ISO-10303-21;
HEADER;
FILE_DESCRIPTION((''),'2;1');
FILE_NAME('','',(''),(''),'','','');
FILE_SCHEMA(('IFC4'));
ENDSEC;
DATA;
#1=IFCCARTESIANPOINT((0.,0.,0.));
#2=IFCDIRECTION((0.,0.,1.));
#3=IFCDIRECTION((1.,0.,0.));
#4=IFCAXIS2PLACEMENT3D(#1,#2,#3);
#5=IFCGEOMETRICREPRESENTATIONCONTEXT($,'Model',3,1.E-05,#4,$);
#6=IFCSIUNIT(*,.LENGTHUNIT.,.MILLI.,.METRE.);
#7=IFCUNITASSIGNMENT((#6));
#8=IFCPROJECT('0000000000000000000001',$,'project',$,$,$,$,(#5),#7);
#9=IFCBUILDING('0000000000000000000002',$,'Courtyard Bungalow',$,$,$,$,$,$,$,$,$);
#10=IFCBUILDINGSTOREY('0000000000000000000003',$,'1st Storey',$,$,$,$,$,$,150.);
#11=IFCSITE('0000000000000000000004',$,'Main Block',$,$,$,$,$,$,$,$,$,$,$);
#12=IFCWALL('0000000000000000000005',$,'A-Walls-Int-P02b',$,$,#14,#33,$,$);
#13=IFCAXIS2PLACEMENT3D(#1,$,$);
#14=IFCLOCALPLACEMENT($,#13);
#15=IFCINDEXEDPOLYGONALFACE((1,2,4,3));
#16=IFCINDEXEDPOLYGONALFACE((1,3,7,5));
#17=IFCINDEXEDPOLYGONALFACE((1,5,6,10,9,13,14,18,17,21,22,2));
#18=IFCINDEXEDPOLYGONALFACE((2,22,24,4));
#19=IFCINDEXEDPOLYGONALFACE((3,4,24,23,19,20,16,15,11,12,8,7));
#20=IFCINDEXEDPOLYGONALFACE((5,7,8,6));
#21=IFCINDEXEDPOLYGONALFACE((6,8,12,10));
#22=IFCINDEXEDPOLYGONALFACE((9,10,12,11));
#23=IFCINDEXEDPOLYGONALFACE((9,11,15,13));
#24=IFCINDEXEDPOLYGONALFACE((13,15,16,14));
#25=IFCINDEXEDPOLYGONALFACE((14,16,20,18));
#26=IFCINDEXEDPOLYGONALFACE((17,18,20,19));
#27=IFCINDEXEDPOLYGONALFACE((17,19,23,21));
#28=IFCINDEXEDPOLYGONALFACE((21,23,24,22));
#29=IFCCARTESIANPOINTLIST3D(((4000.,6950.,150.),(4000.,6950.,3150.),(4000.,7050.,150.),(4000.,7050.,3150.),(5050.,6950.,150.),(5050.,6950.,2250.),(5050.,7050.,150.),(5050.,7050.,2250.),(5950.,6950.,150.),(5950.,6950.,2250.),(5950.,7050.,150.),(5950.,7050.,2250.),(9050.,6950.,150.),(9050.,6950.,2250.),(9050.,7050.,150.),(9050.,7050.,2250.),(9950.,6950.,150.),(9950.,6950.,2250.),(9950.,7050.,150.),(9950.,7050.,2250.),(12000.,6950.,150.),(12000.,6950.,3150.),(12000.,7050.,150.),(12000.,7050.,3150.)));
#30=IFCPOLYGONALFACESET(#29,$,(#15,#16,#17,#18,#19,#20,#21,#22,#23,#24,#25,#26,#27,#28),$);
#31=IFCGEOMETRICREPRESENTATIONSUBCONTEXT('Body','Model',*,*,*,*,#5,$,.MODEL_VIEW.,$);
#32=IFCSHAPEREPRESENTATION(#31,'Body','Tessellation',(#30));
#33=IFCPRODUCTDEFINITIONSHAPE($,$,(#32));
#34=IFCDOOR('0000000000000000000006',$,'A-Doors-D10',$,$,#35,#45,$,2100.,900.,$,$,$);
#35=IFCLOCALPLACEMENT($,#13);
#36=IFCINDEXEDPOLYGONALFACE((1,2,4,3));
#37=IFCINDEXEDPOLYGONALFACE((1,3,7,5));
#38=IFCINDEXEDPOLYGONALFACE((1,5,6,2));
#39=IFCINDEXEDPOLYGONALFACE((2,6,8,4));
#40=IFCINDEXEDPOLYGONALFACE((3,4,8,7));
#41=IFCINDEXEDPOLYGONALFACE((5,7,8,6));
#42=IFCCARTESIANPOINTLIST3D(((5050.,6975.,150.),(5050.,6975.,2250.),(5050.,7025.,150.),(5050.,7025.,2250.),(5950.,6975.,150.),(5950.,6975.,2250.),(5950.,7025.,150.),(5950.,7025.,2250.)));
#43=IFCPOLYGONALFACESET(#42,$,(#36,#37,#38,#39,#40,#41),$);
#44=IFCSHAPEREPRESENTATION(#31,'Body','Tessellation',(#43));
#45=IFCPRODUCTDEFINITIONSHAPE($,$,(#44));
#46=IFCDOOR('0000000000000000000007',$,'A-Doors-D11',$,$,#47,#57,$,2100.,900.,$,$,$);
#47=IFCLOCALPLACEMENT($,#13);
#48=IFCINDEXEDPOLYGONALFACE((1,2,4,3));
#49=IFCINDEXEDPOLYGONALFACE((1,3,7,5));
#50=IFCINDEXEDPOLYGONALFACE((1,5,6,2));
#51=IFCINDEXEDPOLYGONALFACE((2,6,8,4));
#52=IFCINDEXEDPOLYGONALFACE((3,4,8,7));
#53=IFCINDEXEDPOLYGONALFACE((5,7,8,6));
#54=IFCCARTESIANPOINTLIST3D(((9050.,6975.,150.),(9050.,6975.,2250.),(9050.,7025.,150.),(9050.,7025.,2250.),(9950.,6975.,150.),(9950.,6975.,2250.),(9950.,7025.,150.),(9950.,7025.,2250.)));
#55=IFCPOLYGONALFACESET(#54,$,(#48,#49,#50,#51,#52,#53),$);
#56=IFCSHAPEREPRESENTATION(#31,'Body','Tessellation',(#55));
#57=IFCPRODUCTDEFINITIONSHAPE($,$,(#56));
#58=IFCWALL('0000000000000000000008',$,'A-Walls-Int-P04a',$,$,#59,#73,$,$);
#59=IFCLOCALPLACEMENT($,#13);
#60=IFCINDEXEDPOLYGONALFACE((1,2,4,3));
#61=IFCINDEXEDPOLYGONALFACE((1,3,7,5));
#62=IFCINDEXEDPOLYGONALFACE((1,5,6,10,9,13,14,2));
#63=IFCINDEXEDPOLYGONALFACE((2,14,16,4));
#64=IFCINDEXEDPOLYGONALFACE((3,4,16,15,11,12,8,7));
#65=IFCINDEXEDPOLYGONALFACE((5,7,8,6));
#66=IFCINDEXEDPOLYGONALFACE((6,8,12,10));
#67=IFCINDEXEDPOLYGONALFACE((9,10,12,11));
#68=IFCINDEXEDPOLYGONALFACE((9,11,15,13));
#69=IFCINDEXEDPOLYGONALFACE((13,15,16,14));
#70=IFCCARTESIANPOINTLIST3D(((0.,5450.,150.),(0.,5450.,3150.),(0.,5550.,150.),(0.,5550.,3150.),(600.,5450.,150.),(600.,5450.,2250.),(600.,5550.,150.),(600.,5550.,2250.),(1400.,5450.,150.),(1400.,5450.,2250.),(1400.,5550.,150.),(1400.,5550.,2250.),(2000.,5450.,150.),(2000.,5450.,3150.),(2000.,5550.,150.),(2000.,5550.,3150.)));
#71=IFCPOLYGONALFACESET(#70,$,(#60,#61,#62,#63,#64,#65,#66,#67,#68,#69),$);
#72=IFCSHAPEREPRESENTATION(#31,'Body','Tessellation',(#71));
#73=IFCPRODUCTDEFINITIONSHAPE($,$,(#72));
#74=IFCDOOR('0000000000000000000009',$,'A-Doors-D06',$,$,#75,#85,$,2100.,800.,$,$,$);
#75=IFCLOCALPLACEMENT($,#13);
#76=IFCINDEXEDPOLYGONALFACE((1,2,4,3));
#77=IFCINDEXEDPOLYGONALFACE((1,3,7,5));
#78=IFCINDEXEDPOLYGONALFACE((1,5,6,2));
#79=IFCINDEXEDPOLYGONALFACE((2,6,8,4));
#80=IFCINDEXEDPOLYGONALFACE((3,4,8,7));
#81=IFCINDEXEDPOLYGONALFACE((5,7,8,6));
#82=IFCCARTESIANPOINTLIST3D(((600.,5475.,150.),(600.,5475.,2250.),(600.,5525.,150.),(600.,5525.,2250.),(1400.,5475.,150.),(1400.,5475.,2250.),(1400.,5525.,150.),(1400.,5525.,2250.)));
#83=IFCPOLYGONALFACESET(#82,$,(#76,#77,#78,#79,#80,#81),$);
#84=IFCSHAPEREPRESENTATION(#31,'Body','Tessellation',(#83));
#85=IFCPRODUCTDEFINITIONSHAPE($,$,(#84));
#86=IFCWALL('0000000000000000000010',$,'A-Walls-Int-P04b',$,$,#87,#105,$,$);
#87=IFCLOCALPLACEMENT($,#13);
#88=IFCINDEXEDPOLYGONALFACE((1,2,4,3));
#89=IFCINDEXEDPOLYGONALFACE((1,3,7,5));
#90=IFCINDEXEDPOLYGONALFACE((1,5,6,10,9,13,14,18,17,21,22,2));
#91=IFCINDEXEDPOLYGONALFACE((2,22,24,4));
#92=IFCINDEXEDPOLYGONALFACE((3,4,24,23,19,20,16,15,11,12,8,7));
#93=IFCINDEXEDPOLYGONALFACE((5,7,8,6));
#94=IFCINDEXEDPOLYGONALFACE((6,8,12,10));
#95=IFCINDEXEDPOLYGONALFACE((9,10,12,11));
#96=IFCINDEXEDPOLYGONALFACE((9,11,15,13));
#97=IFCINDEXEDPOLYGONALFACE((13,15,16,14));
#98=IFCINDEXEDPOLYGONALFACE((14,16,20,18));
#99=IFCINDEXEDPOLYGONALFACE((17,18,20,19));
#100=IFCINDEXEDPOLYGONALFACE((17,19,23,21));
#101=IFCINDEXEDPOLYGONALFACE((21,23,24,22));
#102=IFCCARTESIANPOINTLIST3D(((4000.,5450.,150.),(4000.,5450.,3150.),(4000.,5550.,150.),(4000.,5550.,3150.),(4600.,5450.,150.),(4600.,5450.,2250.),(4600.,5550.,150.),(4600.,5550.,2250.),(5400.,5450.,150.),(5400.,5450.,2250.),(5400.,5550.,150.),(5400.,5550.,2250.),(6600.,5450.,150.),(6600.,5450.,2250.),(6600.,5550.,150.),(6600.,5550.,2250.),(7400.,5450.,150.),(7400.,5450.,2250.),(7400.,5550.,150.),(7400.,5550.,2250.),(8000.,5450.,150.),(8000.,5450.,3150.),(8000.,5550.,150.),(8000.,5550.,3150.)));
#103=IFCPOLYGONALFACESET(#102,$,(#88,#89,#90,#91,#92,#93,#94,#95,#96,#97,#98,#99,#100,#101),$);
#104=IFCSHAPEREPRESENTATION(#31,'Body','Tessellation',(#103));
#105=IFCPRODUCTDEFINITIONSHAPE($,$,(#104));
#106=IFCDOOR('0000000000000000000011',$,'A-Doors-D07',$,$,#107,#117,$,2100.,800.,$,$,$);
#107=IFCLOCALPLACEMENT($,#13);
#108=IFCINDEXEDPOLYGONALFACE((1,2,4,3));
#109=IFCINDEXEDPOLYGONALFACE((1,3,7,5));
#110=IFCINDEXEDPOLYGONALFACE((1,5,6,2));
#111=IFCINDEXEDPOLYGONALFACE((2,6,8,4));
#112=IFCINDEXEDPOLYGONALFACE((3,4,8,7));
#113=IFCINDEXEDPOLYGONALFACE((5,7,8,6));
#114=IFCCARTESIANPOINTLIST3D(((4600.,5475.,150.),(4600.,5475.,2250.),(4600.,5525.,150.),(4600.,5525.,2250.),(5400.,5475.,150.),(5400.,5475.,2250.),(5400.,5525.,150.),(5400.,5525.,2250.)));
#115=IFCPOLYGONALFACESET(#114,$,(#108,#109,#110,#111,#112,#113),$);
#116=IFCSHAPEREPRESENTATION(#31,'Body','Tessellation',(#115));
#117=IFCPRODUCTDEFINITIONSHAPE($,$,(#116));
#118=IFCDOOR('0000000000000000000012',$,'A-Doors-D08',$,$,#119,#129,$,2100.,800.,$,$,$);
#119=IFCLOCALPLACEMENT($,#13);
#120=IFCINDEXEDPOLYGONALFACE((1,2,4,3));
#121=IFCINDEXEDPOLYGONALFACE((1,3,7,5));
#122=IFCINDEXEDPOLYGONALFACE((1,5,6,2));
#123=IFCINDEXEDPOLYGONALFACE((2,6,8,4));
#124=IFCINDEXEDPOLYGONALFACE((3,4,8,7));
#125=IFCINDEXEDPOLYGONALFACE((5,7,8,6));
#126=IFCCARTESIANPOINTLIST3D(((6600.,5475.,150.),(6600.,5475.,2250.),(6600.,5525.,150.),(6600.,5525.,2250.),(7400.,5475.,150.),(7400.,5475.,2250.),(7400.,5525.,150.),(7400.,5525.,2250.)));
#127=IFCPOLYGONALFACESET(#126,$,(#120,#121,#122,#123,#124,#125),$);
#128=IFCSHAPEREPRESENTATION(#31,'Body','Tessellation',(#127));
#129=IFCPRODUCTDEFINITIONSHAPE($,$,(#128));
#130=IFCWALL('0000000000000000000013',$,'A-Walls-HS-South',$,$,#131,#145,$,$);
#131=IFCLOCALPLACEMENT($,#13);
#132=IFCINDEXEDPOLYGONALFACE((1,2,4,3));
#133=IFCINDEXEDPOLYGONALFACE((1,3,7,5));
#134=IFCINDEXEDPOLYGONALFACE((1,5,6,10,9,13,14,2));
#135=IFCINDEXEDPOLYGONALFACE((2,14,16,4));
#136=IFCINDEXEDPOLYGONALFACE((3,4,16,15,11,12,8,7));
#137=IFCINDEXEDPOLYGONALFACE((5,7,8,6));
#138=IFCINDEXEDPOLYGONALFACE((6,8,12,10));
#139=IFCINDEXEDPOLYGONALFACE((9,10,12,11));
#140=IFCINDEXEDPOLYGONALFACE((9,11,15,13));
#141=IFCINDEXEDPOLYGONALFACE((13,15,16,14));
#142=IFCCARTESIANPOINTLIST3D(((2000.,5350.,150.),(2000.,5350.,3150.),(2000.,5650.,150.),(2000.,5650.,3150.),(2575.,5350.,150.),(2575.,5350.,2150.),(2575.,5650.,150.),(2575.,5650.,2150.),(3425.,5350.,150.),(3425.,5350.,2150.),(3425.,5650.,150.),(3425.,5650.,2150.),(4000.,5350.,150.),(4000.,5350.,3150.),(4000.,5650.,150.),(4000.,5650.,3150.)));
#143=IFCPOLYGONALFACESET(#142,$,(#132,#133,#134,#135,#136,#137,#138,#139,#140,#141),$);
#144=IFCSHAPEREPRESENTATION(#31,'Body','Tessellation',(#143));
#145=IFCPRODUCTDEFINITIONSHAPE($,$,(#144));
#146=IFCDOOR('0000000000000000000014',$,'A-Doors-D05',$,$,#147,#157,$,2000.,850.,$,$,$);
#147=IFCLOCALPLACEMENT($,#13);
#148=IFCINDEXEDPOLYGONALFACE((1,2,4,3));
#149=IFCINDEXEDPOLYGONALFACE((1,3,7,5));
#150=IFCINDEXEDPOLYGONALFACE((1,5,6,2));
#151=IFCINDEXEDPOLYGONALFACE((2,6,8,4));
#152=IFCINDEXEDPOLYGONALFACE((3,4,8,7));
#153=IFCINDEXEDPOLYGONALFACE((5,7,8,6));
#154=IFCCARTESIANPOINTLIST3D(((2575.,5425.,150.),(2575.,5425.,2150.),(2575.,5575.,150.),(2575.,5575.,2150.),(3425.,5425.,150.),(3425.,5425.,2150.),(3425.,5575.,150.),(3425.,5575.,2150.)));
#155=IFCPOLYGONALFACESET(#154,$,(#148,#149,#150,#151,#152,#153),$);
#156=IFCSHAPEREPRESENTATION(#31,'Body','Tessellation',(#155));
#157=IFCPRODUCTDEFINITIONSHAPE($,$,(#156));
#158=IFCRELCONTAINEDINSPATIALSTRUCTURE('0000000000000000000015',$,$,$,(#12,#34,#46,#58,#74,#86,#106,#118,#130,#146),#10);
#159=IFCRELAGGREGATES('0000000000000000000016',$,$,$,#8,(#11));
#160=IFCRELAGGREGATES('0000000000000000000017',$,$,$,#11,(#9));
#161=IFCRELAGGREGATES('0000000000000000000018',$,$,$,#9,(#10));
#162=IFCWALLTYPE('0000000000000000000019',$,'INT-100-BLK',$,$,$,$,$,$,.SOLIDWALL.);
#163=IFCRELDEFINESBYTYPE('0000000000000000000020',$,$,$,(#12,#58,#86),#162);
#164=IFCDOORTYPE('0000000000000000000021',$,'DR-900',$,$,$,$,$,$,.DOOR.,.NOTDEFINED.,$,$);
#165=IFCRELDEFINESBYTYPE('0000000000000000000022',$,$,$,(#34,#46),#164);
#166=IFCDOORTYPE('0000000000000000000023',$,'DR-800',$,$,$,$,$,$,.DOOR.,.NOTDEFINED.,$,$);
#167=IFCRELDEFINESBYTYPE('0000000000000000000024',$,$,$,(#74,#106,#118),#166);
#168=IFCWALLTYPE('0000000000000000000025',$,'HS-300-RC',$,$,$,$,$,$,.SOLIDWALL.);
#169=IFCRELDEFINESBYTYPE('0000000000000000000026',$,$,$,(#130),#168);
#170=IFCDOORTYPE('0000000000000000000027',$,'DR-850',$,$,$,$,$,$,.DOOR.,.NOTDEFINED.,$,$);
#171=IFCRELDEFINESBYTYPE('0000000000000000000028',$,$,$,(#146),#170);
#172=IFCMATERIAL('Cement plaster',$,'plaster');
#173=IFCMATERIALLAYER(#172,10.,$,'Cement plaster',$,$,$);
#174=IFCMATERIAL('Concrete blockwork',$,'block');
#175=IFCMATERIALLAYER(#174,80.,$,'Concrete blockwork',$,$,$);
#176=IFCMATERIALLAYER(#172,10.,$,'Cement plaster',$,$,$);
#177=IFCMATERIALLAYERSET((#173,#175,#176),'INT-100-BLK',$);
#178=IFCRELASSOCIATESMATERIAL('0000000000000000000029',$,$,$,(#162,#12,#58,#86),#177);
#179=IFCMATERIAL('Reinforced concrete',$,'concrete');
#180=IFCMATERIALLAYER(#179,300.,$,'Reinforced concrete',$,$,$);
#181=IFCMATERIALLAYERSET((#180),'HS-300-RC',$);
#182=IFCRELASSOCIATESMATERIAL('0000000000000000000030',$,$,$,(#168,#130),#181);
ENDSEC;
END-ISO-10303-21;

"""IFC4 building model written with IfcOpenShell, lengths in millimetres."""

from ifc_helpers import new_model, si_unit, frame, origin_with_axes, place, context, subcontext, project, spatial, indexed_curve, outline, extrude, material, layer, layer_set, layer_usage, type_object, element, fill, save


model = new_model("IFC4")

# Units and contexts
model_context = context("Model", 3, precision=1e-05, world=origin_with_axes())
body_context = subcontext(model_context, "Body", "Model", "MODEL_VIEW")
ifc_project = project(units=[si_unit("LENGTHUNIT", "METRE", prefix="MILLI")], contexts=[model_context])

# Site, building, storey
site = spatial("IfcSite", under=ifc_project, Name="Main Block")
building = spatial("IfcBuilding", under=site, Name="Courtyard Bungalow")
storey = spatial("IfcBuildingStorey", under=building, Name="1st Storey", Elevation=150.0)

# Shared definitions
ifc_material_1 = material(Name="Reinforced concrete", Category="concrete")

# Shared definitions
ifc_material_2 = material(Name="Cement plaster", Category="plaster")

# Shared definitions
ifc_layer_1 = layer(ifc_material_2, 10.0, Name="Cement plaster")
ifc_material_3 = material(Name="Concrete blockwork", Category="block")
ifc_layer_2 = layer(ifc_material_3, 80.0, Name="Concrete blockwork")
ifc_layer_3 = layer(ifc_material_2, 10.0, Name="Cement plaster")
ifc_layer_set_1 = layer_set([ifc_layer_1, ifc_layer_2, ifc_layer_3], Name="INT-100-BLK")
wall_type_1 = type_object("IfcWallType", Name="INT-100-BLK", PredefinedType="SOLIDWALL", material=ifc_layer_set_1)
door_type_1 = type_object("IfcDoorType", Name="DR-900", OperationType="NOTDEFINED", PredefinedType="DOOR")

# Wall, openings, doors
ifc_layer_usage_1 = layer_usage(ifc_layer_set_1, "AXIS2", "POSITIVE", 0.0)
wall_1_placement = place(None, frame((4000.0, 6950.0, 150.0), z_axis=(0.0, 0.0, 1.0), x_axis=(1.0, 0.0, 0.0)))
wall_1 = element("IfcWall", 1, at=wall_1_placement, inside=storey, type_object=wall_type_1, material=ifc_layer_usage_1, Name="A-Walls-Int-P02b", context=body_context, shape_type="SweptSolid", body=[
    extrude(outline(indexed_curve([(0.0, 0.0), (0.0, 100.0), (8000.0, 100.0), (8000.0, 0.0), (0.0, 0.0)], self_intersect=False)), origin_with_axes(), (0.0, 0.0, 1.0), 3000.0),
])
opening_1_placement = place(wall_1_placement, frame((1500.0, 50.0, 0.0), z_axis=(0.0, 0.0, 1.0), x_axis=(1.0, 0.0, 0.0)))
opening_1 = element("IfcOpeningElement", 2, at=opening_1_placement, cuts=wall_1, PredefinedType="OPENING", context=body_context, shape_type="SweptSolid", body=[
    extrude(outline(indexed_curve([(-450.0, -100.0), (450.0, -100.0), (450.0, 100.0), (-450.0, 100.0)])), None, (0.0, 0.0, 1.0), 2100.0),
])
opening_2_placement = place(wall_1_placement, frame((5500.0, 50.0, 0.0), z_axis=(0.0, 0.0, 1.0), x_axis=(1.0, 0.0, 0.0)))
opening_2 = element("IfcOpeningElement", 3, at=opening_2_placement, cuts=wall_1, PredefinedType="OPENING", context=body_context, shape_type="SweptSolid", body=[
    extrude(outline(indexed_curve([(-450.0, -100.0), (450.0, -100.0), (450.0, 100.0), (-450.0, 100.0)])), None, (0.0, 0.0, 1.0), 2100.0),
])
door_1_placement = place(None, frame((5500.0, 7000.0, 150.0), z_axis=(0.0, 0.0, 1.0), x_axis=(1.0, 0.0, 0.0)))
door_1 = element("IfcDoor", 4, at=door_1_placement, inside=storey, type_object=door_type_1, Name="A-Doors-D10", OverallHeight=2100.0, OverallWidth=900.0, context=body_context, shape_type="SweptSolid", body=[
    extrude(outline(indexed_curve([(-450.0, -25.0), (450.0, -25.0), (450.0, 25.0), (-450.0, 25.0)])), None, (0.0, 0.0, 1.0), 2100.0),
])
fill(opening_1, door_1)
door_2_placement = place(None, frame((9500.0, 7000.0, 150.0), z_axis=(0.0, 0.0, 1.0), x_axis=(1.0, 0.0, 0.0)))
door_2 = element("IfcDoor", 5, at=door_2_placement, inside=storey, type_object=door_type_1, Name="A-Doors-D11", OverallHeight=2100.0, OverallWidth=900.0, context=body_context, shape_type="SweptSolid", body=[
    extrude(outline(indexed_curve([(-450.0, -25.0), (450.0, -25.0), (450.0, 25.0), (-450.0, 25.0)])), None, (0.0, 0.0, 1.0), 2100.0),
])
fill(opening_2, door_2)

# Wall, opening, door
ifc_layer_usage_2 = layer_usage(ifc_layer_set_1, "AXIS2", "POSITIVE", 0.0)
wall_2_placement = place(None, frame((0.0, 5450.0, 150.0), z_axis=(0.0, 0.0, 1.0), x_axis=(1.0, 0.0, 0.0)))
wall_2 = element("IfcWall", 6, at=wall_2_placement, inside=storey, type_object=wall_type_1, material=ifc_layer_usage_2, Name="A-Walls-Int-P04a", context=body_context, shape_type="SweptSolid", body=[
    extrude(outline(indexed_curve([(0.0, 0.0), (0.0, 100.0), (2000.0, 100.0), (2000.0, 0.0), (0.0, 0.0)], self_intersect=False)), origin_with_axes(), (0.0, 0.0, 1.0), 3000.0),
])
opening_3_placement = place(wall_2_placement, frame((1000.0, 50.0, 0.0), z_axis=(0.0, 0.0, 1.0), x_axis=(1.0, 0.0, 0.0)))
opening_3 = element("IfcOpeningElement", 7, at=opening_3_placement, cuts=wall_2, PredefinedType="OPENING", context=body_context, shape_type="SweptSolid", body=[
    extrude(outline(indexed_curve([(-400.0, -100.0), (400.0, -100.0), (400.0, 100.0), (-400.0, 100.0)])), None, (0.0, 0.0, 1.0), 2100.0),
])
door_type_2 = type_object("IfcDoorType", Name="DR-800", OperationType="NOTDEFINED", PredefinedType="DOOR")
door_3_placement = place(None, frame((1000.0, 5500.0, 150.0), z_axis=(0.0, 0.0, 1.0), x_axis=(1.0, 0.0, 0.0)))
door_3 = element("IfcDoor", 8, at=door_3_placement, inside=storey, type_object=door_type_2, Name="A-Doors-D06", OverallHeight=2100.0, OverallWidth=800.0, context=body_context, shape_type="SweptSolid", body=[
    extrude(outline(indexed_curve([(-400.0, -25.0), (400.0, -25.0), (400.0, 25.0), (-400.0, 25.0)])), None, (0.0, 0.0, 1.0), 2100.0),
])
fill(opening_3, door_3)

# Wall, openings, doors
ifc_layer_usage_3 = layer_usage(ifc_layer_set_1, "AXIS2", "POSITIVE", 0.0)
wall_3_placement = place(None, frame((4000.0, 5450.0, 150.0), z_axis=(0.0, 0.0, 1.0), x_axis=(1.0, 0.0, 0.0)))
wall_3 = element("IfcWall", 9, at=wall_3_placement, inside=storey, type_object=wall_type_1, material=ifc_layer_usage_3, Name="A-Walls-Int-P04b", context=body_context, shape_type="SweptSolid", body=[
    extrude(outline(indexed_curve([(0.0, 0.0), (0.0, 100.0), (4000.0, 100.0), (4000.0, 0.0), (0.0, 0.0)], self_intersect=False)), origin_with_axes(), (0.0, 0.0, 1.0), 3000.0),
])
opening_4_placement = place(wall_3_placement, frame((1000.0, 50.0, 0.0), z_axis=(0.0, 0.0, 1.0), x_axis=(1.0, 0.0, 0.0)))
opening_4 = element("IfcOpeningElement", 10, at=opening_4_placement, cuts=wall_3, PredefinedType="OPENING", context=body_context, shape_type="SweptSolid", body=[
    extrude(outline(indexed_curve([(-400.0, -100.0), (400.0, -100.0), (400.0, 100.0), (-400.0, 100.0)])), None, (0.0, 0.0, 1.0), 2100.0),
])
opening_5_placement = place(wall_3_placement, frame((3000.0, 50.0, 0.0), z_axis=(0.0, 0.0, 1.0), x_axis=(1.0, 0.0, 0.0)))
opening_5 = element("IfcOpeningElement", 11, at=opening_5_placement, cuts=wall_3, PredefinedType="OPENING", context=body_context, shape_type="SweptSolid", body=[
    extrude(outline(indexed_curve([(-400.0, -100.0), (400.0, -100.0), (400.0, 100.0), (-400.0, 100.0)])), None, (0.0, 0.0, 1.0), 2100.0),
])
door_4_placement = place(None, frame((5000.0, 5500.0, 150.0), z_axis=(0.0, 0.0, 1.0), x_axis=(1.0, 0.0, 0.0)))
door_4 = element("IfcDoor", 12, at=door_4_placement, inside=storey, type_object=door_type_2, Name="A-Doors-D07", OverallHeight=2100.0, OverallWidth=800.0, context=body_context, shape_type="SweptSolid", body=[
    extrude(outline(indexed_curve([(-400.0, -25.0), (400.0, -25.0), (400.0, 25.0), (-400.0, 25.0)])), None, (0.0, 0.0, 1.0), 2100.0),
])
fill(opening_4, door_4)
door_5_placement = place(None, frame((7000.0, 5500.0, 150.0), z_axis=(0.0, 0.0, 1.0), x_axis=(1.0, 0.0, 0.0)))
door_5 = element("IfcDoor", 13, at=door_5_placement, inside=storey, type_object=door_type_2, Name="A-Doors-D08", OverallHeight=2100.0, OverallWidth=800.0, context=body_context, shape_type="SweptSolid", body=[
    extrude(outline(indexed_curve([(-400.0, -25.0), (400.0, -25.0), (400.0, 25.0), (-400.0, 25.0)])), None, (0.0, 0.0, 1.0), 2100.0),
])
fill(opening_5, door_5)

# Wall, opening, door
ifc_layer_4 = layer(ifc_material_1, 300.0, Name="Reinforced concrete")
ifc_layer_set_2 = layer_set([ifc_layer_4], Name="HS-300-RC")
ifc_layer_usage_4 = layer_usage(ifc_layer_set_2, "AXIS2", "POSITIVE", 0.0)
wall_type_2 = type_object("IfcWallType", Name="HS-300-RC", PredefinedType="SOLIDWALL", material=ifc_layer_set_2)
wall_4_placement = place(None, frame((2000.0, 5350.0, 150.0), z_axis=(0.0, 0.0, 1.0), x_axis=(1.0, 0.0, 0.0)))
wall_4 = element("IfcWall", 14, at=wall_4_placement, inside=storey, type_object=wall_type_2, material=ifc_layer_usage_4, Name="A-Walls-HS-South", context=body_context, shape_type="SweptSolid", body=[
    extrude(outline(indexed_curve([(0.0, 0.0), (0.0, 300.0), (2000.0, 300.0), (2000.0, 0.0), (0.0, 0.0)], self_intersect=False)), origin_with_axes(), (0.0, 0.0, 1.0), 3000.0),
])
opening_6_placement = place(wall_4_placement, frame((1000.0, 150.0, 0.0), z_axis=(0.0, 0.0, 1.0), x_axis=(1.0, 0.0, 0.0)))
opening_6 = element("IfcOpeningElement", 15, at=opening_6_placement, cuts=wall_4, PredefinedType="OPENING", context=body_context, shape_type="SweptSolid", body=[
    extrude(outline(indexed_curve([(-425.0, -200.0), (425.0, -200.0), (425.0, 200.0), (-425.0, 200.0)])), None, (0.0, 0.0, 1.0), 2000.0),
])
door_type_3 = type_object("IfcDoorType", Name="DR-850", OperationType="NOTDEFINED", PredefinedType="DOOR")
door_6_placement = place(None, frame((3000.0, 5500.0, 150.0), z_axis=(0.0, 0.0, 1.0), x_axis=(1.0, 0.0, 0.0)))
door_6 = element("IfcDoor", 16, at=door_6_placement, inside=storey, type_object=door_type_3, Name="A-Doors-D05", OverallHeight=2000.0, OverallWidth=850.0, context=body_context, shape_type="SweptSolid", body=[
    extrude(outline(indexed_curve([(-425.0, -75.0), (425.0, -75.0), (425.0, 75.0), (-425.0, 75.0)])), None, (0.0, 0.0, 1.0), 2000.0),
])
fill(opening_6, door_6)

save(model, "model.ifc")
